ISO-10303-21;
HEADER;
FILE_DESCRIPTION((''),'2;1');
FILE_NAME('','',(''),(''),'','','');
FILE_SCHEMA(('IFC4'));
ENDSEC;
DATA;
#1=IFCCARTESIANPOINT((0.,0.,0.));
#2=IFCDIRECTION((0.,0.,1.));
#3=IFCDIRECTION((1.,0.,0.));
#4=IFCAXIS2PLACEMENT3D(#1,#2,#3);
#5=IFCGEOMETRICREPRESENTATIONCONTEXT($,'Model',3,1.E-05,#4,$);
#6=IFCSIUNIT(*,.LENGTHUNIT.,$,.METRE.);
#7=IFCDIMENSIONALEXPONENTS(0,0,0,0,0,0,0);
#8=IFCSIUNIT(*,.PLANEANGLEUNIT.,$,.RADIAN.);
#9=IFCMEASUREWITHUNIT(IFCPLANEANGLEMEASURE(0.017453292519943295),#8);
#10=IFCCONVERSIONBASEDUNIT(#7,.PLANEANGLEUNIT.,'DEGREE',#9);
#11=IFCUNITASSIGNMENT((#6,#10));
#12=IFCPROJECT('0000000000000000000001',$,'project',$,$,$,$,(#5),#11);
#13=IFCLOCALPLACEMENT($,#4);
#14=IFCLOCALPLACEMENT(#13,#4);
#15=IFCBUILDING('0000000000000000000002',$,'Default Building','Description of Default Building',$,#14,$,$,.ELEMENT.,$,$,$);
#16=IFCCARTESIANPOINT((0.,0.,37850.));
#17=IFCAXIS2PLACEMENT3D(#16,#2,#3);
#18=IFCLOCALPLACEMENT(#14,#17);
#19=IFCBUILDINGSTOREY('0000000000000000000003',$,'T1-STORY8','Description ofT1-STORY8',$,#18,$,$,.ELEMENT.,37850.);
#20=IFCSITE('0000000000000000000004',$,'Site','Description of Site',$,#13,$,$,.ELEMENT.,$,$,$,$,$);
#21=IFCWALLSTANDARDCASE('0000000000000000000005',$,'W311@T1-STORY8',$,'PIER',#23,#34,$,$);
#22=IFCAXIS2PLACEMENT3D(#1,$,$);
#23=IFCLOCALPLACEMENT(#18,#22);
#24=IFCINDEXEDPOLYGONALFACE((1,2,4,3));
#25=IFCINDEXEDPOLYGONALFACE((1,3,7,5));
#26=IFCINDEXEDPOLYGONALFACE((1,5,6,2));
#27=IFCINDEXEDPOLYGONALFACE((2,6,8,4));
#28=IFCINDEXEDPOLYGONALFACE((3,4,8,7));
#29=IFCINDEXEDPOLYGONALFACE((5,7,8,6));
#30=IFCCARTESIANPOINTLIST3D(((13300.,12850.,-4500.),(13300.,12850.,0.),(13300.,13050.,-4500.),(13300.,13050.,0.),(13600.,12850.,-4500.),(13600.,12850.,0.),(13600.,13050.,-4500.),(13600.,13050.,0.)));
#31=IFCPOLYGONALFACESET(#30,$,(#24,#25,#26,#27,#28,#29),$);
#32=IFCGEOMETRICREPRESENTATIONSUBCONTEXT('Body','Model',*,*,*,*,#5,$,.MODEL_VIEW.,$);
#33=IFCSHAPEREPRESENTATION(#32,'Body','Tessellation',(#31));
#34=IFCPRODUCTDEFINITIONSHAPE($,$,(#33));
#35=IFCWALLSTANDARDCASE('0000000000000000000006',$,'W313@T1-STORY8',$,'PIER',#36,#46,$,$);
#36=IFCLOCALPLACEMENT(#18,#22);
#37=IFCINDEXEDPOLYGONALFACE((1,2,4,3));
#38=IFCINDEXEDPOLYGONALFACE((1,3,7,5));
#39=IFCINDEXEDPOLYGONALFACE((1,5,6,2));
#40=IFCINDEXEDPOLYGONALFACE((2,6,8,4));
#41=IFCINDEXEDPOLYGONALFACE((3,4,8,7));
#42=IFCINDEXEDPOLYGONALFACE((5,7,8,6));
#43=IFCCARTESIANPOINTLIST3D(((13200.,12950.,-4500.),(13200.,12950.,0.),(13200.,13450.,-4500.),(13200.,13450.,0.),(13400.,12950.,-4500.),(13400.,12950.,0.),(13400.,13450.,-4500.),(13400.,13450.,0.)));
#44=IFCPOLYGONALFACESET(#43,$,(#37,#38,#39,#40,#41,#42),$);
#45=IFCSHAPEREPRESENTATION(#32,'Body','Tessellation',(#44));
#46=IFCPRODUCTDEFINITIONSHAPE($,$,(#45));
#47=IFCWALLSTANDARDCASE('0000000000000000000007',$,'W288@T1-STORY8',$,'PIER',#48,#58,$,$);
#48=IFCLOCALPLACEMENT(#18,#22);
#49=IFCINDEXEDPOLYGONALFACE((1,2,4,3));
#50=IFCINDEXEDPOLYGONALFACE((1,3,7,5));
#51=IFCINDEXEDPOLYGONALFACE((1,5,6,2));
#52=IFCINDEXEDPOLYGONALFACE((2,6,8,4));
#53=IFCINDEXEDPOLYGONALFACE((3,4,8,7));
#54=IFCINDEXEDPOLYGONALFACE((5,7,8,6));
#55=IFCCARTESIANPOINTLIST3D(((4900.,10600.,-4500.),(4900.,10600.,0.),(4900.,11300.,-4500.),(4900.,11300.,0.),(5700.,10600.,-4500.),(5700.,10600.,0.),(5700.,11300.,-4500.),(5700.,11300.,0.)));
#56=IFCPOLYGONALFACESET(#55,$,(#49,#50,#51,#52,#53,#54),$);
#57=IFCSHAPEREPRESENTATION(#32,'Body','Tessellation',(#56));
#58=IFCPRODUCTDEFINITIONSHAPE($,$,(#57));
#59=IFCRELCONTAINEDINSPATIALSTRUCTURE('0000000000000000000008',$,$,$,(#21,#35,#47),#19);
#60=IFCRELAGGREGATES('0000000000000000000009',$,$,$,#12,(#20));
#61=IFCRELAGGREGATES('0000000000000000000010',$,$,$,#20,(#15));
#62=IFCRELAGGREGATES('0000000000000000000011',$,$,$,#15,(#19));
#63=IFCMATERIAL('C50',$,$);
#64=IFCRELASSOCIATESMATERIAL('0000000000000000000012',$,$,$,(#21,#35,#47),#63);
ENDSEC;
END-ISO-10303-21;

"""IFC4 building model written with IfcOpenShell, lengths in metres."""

from ifc_helpers import new_model, entity, si_unit, converted_unit, frame, origin_with_axes, place, context, subcontext, project, spatial, indexed_curve, outline, extrude, material, element, save


model = new_model("IFC4")

# Units and contexts
model_context = context("Model", 3, precision=1e-05, world=origin_with_axes())
body_context = subcontext(model_context, "Body", "Model", "MODEL_VIEW")
ifc_project = project(units=[si_unit("LENGTHUNIT", "METRE"), converted_unit("PLANEANGLEUNIT", "DEGREE", entity("IfcPlaneAngleMeasure", 0.017453292519943295), si_unit("PLANEANGLEUNIT", "RADIAN"), dimensions=[0, 0, 0, 0, 0, 0, 0])], contexts=[model_context])

# Site, building, storey
site_placement = place(None, origin_with_axes())
site = spatial("IfcSite", under=ifc_project, at=site_placement, Name="Site", Description="Description of Site", CompositionType="ELEMENT")
building_placement = place(site_placement, origin_with_axes())
building = spatial("IfcBuilding", under=site, at=building_placement, Name="Default Building", Description="Description of Default Building", CompositionType="ELEMENT")
storey_placement = place(building_placement, frame((0.0, 0.0, 37850.0), z_axis=(0.0, 0.0, 1.0), x_axis=(1.0, 0.0, 0.0)))
storey = spatial("IfcBuildingStorey", under=building, at=storey_placement, Name="T1-STORY8", Description="Description ofT1-STORY8", CompositionType="ELEMENT", Elevation=37850.0)

# Shared definitions
ifc_material_1 = material(Name="C50")

# Walls
wall_1_placement = place(storey_placement, frame((13300.0, 12950.0, -4500.0), z_axis=(0.0, 0.0, 1.0), x_axis=(1.0, 0.0, 0.0)))
element("IfcWallStandardCase", 1, at=wall_1_placement, inside=storey, material=ifc_material_1, Name="W311@T1-STORY8", ObjectType="PIER", context=body_context, shape_type="SweptSolid", body=[
    extrude(outline(indexed_curve([(0.0, -100.0), (0.0, 100.0), (300.0, 100.0), (300.0, -100.0), (0.0, -100.0)], self_intersect=False)), origin_with_axes(), (0.0, 0.0, 1.0), 4500.0),
])
wall_2_placement = place(storey_placement, frame((13300.0, 12950.0, -4500.0), z_axis=(0.0, 0.0, 1.0), x_axis=(0.0, 1.0, 0.0)))
element("IfcWallStandardCase", 2, at=wall_2_placement, inside=storey, material=ifc_material_1, Name="W313@T1-STORY8", ObjectType="PIER", context=body_context, shape_type="SweptSolid", body=[
    extrude(outline(indexed_curve([(0.0, -100.0), (0.0, 100.0), (500.0, 100.0), (500.0, -100.0), (0.0, -100.0)], self_intersect=False)), origin_with_axes(), (0.0, 0.0, 1.0), 4500.0),
])
wall_3_placement = place(storey_placement, frame((5300.0, 10600.0, -4500.0), z_axis=(0.0, 0.0, 1.0), x_axis=(0.0, 1.0, 0.0)))
element("IfcWallStandardCase", 3, at=wall_3_placement, inside=storey, material=ifc_material_1, Name="W288@T1-STORY8", ObjectType="PIER", context=body_context, shape_type="SweptSolid", body=[
    extrude(outline(indexed_curve([(0.0, -400.0), (0.0, 400.0), (700.0, 400.0), (700.0, -400.0), (0.0, -400.0)], self_intersect=False)), origin_with_axes(), (0.0, 0.0, 1.0), 4500.0),
])

save(model, "model.ifc")
